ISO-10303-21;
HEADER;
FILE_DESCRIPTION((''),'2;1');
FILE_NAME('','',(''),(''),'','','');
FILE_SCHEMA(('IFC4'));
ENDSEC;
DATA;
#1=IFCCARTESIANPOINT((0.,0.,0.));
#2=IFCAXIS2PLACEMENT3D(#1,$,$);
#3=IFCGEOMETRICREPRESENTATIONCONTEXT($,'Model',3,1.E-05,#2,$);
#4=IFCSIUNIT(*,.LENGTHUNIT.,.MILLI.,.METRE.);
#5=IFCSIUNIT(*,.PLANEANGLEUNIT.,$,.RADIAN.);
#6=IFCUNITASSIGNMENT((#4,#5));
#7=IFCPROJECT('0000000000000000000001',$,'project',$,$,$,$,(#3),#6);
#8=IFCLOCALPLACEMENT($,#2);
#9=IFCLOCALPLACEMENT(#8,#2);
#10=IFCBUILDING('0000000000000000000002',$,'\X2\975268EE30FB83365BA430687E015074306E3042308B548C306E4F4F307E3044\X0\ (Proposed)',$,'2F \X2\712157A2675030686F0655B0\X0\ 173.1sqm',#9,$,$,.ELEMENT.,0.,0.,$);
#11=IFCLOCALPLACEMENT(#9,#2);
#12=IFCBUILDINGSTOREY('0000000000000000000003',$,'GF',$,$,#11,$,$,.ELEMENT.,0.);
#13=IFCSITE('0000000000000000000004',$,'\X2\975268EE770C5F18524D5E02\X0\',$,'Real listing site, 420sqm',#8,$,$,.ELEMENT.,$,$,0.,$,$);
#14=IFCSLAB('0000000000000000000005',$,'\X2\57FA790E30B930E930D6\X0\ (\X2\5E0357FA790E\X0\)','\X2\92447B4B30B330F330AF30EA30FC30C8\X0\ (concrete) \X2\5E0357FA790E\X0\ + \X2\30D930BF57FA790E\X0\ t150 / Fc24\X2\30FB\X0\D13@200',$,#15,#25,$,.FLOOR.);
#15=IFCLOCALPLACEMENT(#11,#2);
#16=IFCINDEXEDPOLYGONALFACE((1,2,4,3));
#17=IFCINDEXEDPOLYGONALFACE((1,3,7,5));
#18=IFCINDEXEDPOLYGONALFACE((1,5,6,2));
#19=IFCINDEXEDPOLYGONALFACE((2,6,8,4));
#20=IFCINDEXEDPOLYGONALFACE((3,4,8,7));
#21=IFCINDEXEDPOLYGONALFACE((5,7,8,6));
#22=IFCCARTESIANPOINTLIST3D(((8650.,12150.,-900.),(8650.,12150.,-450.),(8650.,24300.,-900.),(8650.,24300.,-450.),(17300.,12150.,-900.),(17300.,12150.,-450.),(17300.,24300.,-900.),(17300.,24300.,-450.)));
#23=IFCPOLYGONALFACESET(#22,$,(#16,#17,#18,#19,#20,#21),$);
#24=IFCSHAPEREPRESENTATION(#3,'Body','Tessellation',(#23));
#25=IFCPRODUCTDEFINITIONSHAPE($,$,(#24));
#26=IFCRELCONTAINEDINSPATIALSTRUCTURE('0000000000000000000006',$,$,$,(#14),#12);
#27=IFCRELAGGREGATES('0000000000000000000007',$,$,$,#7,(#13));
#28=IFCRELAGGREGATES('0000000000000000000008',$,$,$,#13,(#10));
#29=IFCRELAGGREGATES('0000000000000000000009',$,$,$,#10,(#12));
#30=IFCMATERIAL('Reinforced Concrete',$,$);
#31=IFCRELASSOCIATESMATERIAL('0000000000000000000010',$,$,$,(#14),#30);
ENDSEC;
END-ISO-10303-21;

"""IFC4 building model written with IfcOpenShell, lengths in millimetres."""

from ifc_helpers import new_model, si_unit, frame, frame_2d, origin, place, context, project, spatial, rectangle, extrude, material, element, save


model = new_model("IFC4")

# Units and contexts
model_context = context("Model", 3, precision=1e-05, world=origin())
ifc_project = project(units=[si_unit("LENGTHUNIT", "METRE", prefix="MILLI"), si_unit("PLANEANGLEUNIT", "RADIAN")], contexts=[model_context])

# Site, building, storey
site_placement = place(None, origin())
site = spatial("IfcSite", under=ifc_project, at=site_placement, Name="青森県弘前市", ObjectType="Real listing site, 420sqm", CompositionType="ELEMENT", RefElevation=0.0)
building_placement = place(site_placement, origin())
building = spatial("IfcBuilding", under=site, at=building_placement, Name="青森・茶室と縁側のある和の住まい (Proposed)", ObjectType="2F 無垢材と漆喰 173.1sqm", CompositionType="ELEMENT", ElevationOfRefHeight=0.0, ElevationOfTerrain=0.0)
storey_placement = place(building_placement, origin())
storey = spatial("IfcBuildingStorey", under=building, at=storey_placement, Name="GF", CompositionType="ELEMENT", Elevation=0.0)

# Slab
ifc_material_1 = material(Name="Reinforced Concrete")
slab_1_placement = place(storey_placement, frame((4325.0, 6075.0, -450.0)))
element("IfcSlab", 1, at=slab_1_placement, inside=storey, material=ifc_material_1, Name="基礎スラブ (布基礎)", Description="鉄筋コンクリート (concrete) 布基礎 + ベタ基礎 t150 / Fc24・D13@200", PredefinedType="FLOOR", context=model_context, shape_type="SweptSolid", body=[
    extrude(rectangle(XDim=8650.0, YDim=12150.0, at=frame_2d((4325.0, 6075.0))), frame((4325.0, 6075.0, -450.0)), (0.0, 0.0, 1.0), 450.0),
])

save(model, "model.ifc")
